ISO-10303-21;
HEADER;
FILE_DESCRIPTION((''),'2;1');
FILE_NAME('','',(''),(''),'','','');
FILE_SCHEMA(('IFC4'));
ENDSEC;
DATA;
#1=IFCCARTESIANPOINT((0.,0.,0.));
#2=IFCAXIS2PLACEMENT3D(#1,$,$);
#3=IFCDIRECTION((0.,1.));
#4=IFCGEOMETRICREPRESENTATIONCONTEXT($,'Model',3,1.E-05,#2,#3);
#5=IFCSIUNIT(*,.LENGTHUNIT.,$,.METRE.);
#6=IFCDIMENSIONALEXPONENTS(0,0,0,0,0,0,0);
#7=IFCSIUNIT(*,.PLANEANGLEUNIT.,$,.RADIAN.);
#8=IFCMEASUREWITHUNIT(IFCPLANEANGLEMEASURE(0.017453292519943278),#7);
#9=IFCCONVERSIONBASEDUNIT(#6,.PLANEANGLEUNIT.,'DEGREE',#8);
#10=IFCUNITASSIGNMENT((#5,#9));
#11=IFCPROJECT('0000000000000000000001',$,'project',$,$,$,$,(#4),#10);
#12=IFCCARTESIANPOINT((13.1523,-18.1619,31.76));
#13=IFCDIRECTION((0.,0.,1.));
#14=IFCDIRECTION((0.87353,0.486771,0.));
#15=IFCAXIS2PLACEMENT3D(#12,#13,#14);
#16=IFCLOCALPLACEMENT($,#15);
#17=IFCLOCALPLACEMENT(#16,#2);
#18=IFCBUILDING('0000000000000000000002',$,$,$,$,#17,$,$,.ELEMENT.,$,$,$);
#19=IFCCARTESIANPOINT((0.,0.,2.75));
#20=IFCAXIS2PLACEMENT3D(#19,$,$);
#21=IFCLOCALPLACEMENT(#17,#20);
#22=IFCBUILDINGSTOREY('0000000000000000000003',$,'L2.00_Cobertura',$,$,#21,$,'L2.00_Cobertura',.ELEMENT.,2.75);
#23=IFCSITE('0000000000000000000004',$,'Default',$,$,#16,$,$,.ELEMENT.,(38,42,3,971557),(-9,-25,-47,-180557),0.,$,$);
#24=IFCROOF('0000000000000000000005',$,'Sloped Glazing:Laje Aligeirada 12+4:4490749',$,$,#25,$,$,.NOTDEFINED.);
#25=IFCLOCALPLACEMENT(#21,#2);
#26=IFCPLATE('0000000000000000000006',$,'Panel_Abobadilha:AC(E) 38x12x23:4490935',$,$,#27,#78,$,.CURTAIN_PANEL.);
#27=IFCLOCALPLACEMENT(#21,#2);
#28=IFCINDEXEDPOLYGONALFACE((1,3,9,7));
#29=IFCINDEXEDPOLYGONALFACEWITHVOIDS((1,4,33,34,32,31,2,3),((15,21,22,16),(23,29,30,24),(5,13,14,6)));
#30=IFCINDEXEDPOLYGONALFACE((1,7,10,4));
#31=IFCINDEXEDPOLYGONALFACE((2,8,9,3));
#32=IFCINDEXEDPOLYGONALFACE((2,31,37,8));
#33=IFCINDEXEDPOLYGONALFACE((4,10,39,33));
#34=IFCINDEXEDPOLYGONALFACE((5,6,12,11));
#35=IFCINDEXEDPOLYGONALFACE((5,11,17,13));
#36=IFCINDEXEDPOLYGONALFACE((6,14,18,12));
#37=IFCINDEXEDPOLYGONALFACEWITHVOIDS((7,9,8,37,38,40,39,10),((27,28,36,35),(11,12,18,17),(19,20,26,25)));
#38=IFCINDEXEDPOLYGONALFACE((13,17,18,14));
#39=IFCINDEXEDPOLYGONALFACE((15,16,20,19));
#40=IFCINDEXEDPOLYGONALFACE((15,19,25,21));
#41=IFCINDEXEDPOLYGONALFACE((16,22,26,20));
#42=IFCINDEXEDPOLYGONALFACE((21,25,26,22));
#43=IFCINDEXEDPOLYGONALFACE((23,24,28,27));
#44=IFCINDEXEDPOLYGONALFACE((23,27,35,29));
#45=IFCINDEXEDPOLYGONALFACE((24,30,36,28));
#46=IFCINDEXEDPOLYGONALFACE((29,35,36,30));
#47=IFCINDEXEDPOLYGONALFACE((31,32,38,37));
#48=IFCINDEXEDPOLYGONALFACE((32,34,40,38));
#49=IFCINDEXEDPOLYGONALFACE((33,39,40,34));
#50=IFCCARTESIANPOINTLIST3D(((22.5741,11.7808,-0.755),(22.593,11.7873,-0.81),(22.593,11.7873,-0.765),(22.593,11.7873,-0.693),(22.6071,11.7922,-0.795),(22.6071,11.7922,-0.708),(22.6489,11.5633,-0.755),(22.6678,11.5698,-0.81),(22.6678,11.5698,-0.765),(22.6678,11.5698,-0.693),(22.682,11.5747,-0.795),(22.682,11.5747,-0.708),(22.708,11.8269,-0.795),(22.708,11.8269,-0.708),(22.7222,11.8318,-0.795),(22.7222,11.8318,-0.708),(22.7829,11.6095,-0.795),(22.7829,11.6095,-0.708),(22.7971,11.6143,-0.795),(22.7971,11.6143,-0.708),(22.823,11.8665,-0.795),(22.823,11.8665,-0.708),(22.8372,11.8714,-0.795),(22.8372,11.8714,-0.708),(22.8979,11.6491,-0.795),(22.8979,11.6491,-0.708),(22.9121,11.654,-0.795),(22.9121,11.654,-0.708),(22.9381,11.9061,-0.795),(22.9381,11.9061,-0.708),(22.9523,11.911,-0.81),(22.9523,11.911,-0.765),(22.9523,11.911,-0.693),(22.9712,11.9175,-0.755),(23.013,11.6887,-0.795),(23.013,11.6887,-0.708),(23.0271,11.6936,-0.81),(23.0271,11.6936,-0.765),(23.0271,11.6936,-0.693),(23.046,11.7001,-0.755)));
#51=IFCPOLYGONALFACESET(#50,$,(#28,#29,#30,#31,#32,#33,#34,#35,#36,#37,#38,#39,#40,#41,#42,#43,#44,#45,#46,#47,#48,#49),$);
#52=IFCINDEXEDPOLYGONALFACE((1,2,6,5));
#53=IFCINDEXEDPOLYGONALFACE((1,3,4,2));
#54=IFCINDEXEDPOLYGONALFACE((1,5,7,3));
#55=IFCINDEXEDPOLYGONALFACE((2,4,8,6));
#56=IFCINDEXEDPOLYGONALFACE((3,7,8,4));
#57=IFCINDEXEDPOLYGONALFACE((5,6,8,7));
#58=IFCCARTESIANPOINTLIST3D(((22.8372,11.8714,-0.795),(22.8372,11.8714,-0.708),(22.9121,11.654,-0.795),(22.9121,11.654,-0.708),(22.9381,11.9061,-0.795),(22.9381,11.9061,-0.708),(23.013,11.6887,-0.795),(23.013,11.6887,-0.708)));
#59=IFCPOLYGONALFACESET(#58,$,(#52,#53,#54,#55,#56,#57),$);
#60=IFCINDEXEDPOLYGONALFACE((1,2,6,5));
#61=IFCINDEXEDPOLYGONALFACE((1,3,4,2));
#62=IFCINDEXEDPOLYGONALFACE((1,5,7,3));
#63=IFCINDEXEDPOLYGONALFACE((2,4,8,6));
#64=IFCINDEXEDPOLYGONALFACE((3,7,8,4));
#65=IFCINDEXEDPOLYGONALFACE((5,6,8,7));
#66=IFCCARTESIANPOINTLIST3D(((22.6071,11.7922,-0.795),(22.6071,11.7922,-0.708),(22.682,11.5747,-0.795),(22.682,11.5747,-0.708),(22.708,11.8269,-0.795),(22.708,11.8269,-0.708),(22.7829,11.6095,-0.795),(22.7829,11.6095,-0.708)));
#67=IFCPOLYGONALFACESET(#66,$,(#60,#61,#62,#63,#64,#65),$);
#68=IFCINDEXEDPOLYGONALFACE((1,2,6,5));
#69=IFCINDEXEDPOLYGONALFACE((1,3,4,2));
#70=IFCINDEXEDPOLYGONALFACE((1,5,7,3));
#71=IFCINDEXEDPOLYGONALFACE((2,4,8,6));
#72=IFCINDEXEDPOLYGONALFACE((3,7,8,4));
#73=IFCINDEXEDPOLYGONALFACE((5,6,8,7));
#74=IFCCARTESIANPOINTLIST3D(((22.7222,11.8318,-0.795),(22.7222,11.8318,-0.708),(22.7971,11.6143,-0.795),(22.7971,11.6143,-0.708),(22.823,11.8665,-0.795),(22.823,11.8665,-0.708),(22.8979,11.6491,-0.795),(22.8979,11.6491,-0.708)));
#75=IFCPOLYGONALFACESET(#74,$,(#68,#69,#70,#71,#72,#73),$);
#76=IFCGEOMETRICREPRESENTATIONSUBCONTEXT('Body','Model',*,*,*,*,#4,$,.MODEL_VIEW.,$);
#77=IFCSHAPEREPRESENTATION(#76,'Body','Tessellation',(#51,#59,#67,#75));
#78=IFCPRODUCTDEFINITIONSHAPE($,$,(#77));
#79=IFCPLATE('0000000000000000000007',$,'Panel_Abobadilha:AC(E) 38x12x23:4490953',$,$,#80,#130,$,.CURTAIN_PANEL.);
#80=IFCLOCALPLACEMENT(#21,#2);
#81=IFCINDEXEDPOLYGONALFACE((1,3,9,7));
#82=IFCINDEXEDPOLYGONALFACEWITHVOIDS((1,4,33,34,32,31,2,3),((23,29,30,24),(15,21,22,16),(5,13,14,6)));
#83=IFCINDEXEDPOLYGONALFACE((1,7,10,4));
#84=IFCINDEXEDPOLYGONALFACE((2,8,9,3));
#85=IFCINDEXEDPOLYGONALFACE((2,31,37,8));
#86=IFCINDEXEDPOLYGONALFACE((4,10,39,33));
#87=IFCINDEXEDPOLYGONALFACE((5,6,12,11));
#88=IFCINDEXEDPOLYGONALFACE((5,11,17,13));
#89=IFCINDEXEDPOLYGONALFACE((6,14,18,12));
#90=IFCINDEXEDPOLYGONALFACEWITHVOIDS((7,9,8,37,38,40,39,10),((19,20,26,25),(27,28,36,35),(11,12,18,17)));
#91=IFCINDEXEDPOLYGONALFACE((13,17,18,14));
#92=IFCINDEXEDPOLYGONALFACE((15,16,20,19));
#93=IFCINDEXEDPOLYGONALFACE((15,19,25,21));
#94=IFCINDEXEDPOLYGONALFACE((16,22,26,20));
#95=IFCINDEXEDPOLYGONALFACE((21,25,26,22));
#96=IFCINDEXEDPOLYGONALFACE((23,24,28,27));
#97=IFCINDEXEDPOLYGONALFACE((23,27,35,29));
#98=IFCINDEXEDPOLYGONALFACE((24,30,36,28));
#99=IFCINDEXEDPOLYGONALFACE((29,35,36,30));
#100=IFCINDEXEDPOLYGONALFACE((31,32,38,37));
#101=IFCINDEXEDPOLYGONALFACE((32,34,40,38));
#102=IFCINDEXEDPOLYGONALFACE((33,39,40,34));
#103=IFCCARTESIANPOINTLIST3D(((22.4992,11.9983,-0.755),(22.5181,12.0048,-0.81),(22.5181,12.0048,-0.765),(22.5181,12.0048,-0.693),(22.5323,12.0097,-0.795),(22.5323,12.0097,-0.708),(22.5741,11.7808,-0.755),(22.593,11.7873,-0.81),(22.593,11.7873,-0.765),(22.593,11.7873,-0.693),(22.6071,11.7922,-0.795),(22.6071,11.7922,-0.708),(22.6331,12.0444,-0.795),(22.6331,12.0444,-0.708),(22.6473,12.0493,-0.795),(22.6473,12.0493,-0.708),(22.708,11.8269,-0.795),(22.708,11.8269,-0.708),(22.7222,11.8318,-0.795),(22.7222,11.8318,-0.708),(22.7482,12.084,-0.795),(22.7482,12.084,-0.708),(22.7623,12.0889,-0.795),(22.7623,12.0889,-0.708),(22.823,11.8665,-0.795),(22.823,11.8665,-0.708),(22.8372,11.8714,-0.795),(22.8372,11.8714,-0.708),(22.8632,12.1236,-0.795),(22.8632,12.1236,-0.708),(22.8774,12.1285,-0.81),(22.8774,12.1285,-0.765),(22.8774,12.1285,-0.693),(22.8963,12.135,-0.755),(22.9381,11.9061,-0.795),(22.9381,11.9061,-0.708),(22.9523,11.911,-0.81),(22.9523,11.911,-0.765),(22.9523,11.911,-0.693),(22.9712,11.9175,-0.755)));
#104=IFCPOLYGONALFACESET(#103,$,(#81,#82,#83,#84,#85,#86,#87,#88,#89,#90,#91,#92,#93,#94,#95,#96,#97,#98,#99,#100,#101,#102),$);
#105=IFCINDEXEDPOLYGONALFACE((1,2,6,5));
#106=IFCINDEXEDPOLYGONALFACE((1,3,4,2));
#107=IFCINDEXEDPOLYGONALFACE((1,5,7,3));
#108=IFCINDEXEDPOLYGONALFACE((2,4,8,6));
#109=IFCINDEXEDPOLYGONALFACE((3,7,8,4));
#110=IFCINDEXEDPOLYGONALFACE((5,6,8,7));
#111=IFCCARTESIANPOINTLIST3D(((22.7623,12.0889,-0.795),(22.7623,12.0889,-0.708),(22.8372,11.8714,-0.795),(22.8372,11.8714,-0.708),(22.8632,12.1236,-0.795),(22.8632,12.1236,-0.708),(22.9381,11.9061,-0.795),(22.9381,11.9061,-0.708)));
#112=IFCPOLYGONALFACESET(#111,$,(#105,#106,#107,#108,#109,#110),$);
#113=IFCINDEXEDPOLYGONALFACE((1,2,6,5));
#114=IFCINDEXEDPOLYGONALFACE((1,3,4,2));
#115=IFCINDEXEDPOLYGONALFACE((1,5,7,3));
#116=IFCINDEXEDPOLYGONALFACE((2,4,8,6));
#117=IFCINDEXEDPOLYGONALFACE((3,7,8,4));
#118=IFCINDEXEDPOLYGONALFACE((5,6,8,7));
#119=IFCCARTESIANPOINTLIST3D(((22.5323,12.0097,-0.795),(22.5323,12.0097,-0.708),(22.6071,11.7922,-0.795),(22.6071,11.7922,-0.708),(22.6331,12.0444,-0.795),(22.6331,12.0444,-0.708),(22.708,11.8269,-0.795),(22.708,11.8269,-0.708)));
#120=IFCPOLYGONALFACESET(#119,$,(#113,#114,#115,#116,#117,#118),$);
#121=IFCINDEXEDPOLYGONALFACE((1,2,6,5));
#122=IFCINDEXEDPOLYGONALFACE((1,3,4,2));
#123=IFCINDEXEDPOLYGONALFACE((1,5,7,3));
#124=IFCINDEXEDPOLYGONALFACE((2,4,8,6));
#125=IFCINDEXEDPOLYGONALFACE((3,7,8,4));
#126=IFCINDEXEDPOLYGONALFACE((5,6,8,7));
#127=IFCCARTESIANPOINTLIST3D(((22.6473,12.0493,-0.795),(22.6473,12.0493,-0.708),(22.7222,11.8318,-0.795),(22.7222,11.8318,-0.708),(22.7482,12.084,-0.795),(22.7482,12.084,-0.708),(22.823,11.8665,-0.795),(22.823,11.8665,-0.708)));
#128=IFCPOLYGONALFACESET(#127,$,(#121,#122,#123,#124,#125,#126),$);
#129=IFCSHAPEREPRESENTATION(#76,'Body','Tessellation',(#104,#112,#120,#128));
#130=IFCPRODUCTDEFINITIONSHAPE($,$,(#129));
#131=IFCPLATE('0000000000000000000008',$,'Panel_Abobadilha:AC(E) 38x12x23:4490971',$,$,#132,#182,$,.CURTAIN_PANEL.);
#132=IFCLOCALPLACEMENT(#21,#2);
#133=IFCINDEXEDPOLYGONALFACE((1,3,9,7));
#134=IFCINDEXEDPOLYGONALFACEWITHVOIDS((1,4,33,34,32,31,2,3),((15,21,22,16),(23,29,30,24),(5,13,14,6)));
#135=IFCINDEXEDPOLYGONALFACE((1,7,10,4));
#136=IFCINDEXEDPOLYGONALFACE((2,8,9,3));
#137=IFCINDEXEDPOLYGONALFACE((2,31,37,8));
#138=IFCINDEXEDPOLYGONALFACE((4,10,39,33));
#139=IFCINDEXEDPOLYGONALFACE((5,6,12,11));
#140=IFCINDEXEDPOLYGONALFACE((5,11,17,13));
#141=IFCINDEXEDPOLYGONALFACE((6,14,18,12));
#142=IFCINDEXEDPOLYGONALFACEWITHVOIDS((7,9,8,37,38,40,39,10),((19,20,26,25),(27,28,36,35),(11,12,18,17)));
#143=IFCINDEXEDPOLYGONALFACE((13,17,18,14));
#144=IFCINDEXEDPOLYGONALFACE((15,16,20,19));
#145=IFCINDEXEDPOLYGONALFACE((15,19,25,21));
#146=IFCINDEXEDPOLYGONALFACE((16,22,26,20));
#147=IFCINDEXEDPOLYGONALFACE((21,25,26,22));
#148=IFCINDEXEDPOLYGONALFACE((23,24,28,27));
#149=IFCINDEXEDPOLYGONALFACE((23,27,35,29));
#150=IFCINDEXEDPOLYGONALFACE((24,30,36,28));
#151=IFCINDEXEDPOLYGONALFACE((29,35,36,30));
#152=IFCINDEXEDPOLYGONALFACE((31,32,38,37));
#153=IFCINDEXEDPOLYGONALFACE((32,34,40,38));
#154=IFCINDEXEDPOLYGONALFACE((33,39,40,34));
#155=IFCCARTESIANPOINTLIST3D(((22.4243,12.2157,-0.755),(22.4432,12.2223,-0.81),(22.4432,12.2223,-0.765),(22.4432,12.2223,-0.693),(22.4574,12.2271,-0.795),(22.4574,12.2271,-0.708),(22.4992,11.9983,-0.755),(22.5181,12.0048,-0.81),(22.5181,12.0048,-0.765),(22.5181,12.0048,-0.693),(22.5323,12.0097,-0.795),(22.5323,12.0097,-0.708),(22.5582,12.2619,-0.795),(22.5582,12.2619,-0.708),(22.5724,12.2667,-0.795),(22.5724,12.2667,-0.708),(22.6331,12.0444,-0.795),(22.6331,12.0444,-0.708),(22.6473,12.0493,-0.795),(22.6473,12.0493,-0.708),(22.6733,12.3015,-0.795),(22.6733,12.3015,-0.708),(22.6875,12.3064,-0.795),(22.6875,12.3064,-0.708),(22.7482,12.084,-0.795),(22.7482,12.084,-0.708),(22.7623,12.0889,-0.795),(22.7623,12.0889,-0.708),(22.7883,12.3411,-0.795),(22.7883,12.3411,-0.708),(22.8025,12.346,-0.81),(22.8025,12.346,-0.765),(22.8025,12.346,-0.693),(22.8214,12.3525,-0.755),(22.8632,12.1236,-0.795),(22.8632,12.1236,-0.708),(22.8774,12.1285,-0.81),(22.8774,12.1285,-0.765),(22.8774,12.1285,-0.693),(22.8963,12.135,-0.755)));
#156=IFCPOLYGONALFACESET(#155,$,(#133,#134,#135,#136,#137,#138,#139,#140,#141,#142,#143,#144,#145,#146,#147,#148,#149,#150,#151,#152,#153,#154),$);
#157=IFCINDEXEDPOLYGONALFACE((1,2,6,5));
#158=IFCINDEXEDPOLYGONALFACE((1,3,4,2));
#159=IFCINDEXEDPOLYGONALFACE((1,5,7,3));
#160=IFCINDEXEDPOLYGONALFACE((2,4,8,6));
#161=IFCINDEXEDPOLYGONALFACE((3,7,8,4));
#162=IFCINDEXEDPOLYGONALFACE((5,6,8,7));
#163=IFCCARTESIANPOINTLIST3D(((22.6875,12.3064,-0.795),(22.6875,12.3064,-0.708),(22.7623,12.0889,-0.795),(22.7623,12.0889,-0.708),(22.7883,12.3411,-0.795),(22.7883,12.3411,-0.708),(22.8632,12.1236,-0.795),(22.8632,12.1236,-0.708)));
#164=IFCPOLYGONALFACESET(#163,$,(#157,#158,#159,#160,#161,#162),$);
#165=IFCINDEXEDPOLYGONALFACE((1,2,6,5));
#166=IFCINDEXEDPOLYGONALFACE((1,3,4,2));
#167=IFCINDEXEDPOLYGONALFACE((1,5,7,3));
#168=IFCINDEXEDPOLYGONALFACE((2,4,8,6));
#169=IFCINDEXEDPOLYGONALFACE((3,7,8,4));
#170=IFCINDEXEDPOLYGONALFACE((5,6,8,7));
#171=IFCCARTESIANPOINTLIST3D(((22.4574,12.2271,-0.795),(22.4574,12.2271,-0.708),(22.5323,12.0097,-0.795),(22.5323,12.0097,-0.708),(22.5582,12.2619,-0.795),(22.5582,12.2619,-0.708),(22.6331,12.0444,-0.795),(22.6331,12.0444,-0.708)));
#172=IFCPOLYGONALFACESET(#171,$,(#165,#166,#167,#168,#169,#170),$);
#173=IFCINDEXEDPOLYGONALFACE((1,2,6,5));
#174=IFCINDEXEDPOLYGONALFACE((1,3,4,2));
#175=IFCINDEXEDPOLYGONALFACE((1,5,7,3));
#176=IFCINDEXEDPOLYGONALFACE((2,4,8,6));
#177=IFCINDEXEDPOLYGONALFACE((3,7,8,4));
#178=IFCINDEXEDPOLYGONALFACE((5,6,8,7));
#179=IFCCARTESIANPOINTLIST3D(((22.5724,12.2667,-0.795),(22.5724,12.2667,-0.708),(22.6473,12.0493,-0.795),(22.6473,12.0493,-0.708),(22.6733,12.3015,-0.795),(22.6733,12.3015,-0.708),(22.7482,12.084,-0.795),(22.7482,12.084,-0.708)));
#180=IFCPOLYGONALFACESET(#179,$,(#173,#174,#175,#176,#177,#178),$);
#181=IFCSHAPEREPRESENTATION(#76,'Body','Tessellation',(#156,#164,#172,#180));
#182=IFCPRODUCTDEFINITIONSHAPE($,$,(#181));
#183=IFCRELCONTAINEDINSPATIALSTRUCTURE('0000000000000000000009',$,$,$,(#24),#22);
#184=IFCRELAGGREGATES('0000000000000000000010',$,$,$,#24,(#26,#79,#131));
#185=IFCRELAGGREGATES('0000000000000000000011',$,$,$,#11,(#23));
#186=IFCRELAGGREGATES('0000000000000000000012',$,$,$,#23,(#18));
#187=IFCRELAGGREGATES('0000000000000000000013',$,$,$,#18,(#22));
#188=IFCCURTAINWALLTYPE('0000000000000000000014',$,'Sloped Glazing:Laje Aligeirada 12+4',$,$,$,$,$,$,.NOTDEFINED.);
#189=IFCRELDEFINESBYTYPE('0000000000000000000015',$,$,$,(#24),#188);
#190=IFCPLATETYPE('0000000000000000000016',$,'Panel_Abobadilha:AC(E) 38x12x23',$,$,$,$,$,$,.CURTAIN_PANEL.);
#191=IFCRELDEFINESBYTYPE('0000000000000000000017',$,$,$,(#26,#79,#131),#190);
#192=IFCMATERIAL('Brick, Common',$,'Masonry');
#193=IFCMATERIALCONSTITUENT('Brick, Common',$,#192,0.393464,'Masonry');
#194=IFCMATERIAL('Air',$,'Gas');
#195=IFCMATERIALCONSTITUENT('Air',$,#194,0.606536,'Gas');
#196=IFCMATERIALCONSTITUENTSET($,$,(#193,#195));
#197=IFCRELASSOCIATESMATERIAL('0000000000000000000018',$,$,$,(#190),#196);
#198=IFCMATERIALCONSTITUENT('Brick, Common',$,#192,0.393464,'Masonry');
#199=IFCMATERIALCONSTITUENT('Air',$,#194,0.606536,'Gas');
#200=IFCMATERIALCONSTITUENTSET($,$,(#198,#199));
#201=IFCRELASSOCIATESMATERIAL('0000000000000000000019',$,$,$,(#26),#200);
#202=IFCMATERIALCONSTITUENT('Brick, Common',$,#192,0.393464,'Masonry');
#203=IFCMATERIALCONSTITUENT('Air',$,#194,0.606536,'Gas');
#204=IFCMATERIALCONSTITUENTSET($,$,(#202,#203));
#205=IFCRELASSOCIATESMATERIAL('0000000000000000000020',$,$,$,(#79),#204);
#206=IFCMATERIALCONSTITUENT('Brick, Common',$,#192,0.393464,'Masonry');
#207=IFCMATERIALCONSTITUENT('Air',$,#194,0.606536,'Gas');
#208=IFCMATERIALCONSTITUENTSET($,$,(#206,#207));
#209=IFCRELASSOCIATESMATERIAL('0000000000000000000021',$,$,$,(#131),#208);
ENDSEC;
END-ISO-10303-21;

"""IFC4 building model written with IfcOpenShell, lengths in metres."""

from ifc_helpers import new_model, entity, si_unit, converted_unit, direction, frame, origin, place, context, subcontext, project, spatial, indexed_curve, outline, extrude, source, transform, mapped, material, constituent, constituent_set, type_object, type_shapes, element, aggregate, save


model = new_model("IFC4")

# Units and contexts
model_context = context("Model", 3, precision=1e-05, world=origin(), true_north=direction((0.0, 1.0)))
body_context = subcontext(model_context, "Body", "Model", "MODEL_VIEW")
ifc_project = project(units=[si_unit("LENGTHUNIT", "METRE"), converted_unit("PLANEANGLEUNIT", "DEGREE", entity("IfcPlaneAngleMeasure", 0.017453292519943278), si_unit("PLANEANGLEUNIT", "RADIAN"), dimensions=[0, 0, 0, 0, 0, 0, 0])], contexts=[model_context])

# Site, building, storey
site_placement = place(None, frame((13.1523, -18.1619, 31.76), z_axis=(0.0, 0.0, 1.0), x_axis=(0.87353, 0.486771, 0.0)))
site = spatial("IfcSite", under=ifc_project, at=site_placement, Name="Default", CompositionType="ELEMENT", RefLatitude=(38, 42, 3, 971557), RefLongitude=(-9, -25, -47, -180557), RefElevation=0.0)
building_placement = place(site_placement, origin())
building = spatial("IfcBuilding", under=site, at=building_placement, CompositionType="ELEMENT")
storey_placement = place(building_placement, frame((0.0, 0.0, 2.75)))
storey = spatial("IfcBuildingStorey", under=building, at=storey_placement, Name="L2.00_Cobertura", LongName="L2.00_Cobertura", CompositionType="ELEMENT", Elevation=2.75)

# Roof, plates
curtain_wall_type = type_object("IfcCurtainWallType", Name="Sloped Glazing:Laje Aligeirada 12+4", PredefinedType="NOTDEFINED")
roof_placement = place(storey_placement, frame((0.0, 0.0, -2.75)))
roof = element("IfcRoof", 1, at=roof_placement, inside=storey, type_object=curtain_wall_type, Name="Sloped Glazing:Laje Aligeirada 12+4:4490749", PredefinedType="NOTDEFINED")
ifc_material_1 = material(Name="Brick, Common", Category="Masonry")
ifc_constituent_1 = constituent(ifc_material_1, Name="Brick, Common", Category="Masonry", fraction=0.393464)
ifc_material_2 = material(Name="Air", Category="Gas")
ifc_constituent_2 = constituent(ifc_material_2, Name="Air", Category="Gas", fraction=0.606536)
ifc_constituent_set_1 = constituent_set(constituents=[ifc_constituent_1, ifc_constituent_2])
ifc_constituent_3 = constituent(ifc_material_1, Name="Brick, Common", Category="Masonry", fraction=0.393464)
ifc_constituent_4 = constituent(ifc_material_2, Name="Air", Category="Gas", fraction=0.606536)
ifc_constituent_set_2 = constituent_set(constituents=[ifc_constituent_3, ifc_constituent_4])
plate_type = type_object("IfcPlateType", Name="Panel_Abobadilha:AC(E) 38x12x23", PredefinedType="CURTAIN_PANEL", material=ifc_constituent_set_2)
shared_shape_1 = source(origin(), body_context, "Body", "SweptSolid", [
    extrude(outline(indexed_curve([(-0.19, -0.0543), (0.19, -0.0543), (0.19, -0.0093), (0.21, 0.0007), (0.19, 0.0628), (-0.19, 0.0628), (-0.21, 0.0007), (-0.19, -0.0093), (-0.19, -0.0543)], self_intersect=False), holes=[indexed_curve([(-0.0683, 0.0477), (-0.0683, -0.0393), (-0.175, -0.0393), (-0.175, 0.0477), (-0.0683, 0.0477)], self_intersect=False), indexed_curve([(0.0533, 0.0477), (0.0533, -0.0393), (-0.0533, -0.0393), (-0.0533, 0.0477), (0.0533, 0.0477)], self_intersect=False), indexed_curve([(0.175, 0.0477), (0.175, -0.0393), (0.0683, -0.0393), (0.0683, 0.0477), (0.175, 0.0477)], self_intersect=False)]), frame((0.0, 0.0543, 0.0)), (0.0, 0.0, 1.0), 0.23),
    extrude(outline(indexed_curve([(-0.0533, -0.0435), (0.0533, -0.0435), (0.0533, 0.0435), (-0.0533, 0.0435), (-0.0533, -0.0435)], self_intersect=False)), frame((0.1217, 0.0585, 0.0), z_axis=(0.0, 0.0, 1.0), x_axis=(-1.0, 0.0, 0.0)), (0.0, 0.0, 1.0), 0.23),
    extrude(outline(indexed_curve([(-0.0533, -0.0435), (0.0533, -0.0435), (0.0533, 0.0435), (-0.0533, 0.0435), (-0.0533, -0.0435)], self_intersect=False)), frame((-0.1217, 0.0585, 0.0), z_axis=(0.0, 0.0, 1.0), x_axis=(-1.0, 0.0, 0.0)), (0.0, 0.0, 1.0), 0.23),
    extrude(outline(indexed_curve([(-0.0533, -0.0435), (0.0533, -0.0435), (0.0533, 0.0435), (-0.0533, 0.0435), (-0.0533, -0.0435)], self_intersect=False)), frame((0.0, 0.0585, 0.0), z_axis=(0.0, 0.0, 1.0), x_axis=(-1.0, 0.0, 0.0)), (0.0, 0.0, 1.0), 0.23),
])
type_shapes(plate_type, [shared_shape_1])
plate_1_placement = place(roof_placement, frame((22.7726, 11.8492, 1.94), z_axis=(0.325568, -0.945519, 0.0), x_axis=(0.945519, 0.325568, 0.0)))
plate_1 = element("IfcPlate", 2, at=plate_1_placement, type_object=plate_type, material=ifc_constituent_set_1, Name="Panel_Abobadilha:AC(E) 38x12x23:4490935", PredefinedType="CURTAIN_PANEL", context=body_context, shape_type="MappedRepresentation", body=[
    mapped(shared_shape_1, transform((0.0, 0.0, 0.0), scale=1.0)),
])
ifc_constituent_5 = constituent(ifc_material_1, Name="Brick, Common", Category="Masonry", fraction=0.393464)
ifc_constituent_6 = constituent(ifc_material_2, Name="Air", Category="Gas", fraction=0.606536)
ifc_constituent_set_3 = constituent_set(constituents=[ifc_constituent_5, ifc_constituent_6])
plate_2_placement = place(roof_placement, frame((22.6977, 12.0666, 1.94), z_axis=(0.325568, -0.945519, 0.0), x_axis=(0.945519, 0.325568, 0.0)))
plate_2 = element("IfcPlate", 3, at=plate_2_placement, type_object=plate_type, material=ifc_constituent_set_3, Name="Panel_Abobadilha:AC(E) 38x12x23:4490953", PredefinedType="CURTAIN_PANEL", context=body_context, shape_type="MappedRepresentation", body=[
    mapped(shared_shape_1, transform((0.0, 0.0, 0.0), scale=1.0)),
])
ifc_constituent_7 = constituent(ifc_material_1, Name="Brick, Common", Category="Masonry", fraction=0.393464)
ifc_constituent_8 = constituent(ifc_material_2, Name="Air", Category="Gas", fraction=0.606536)
ifc_constituent_set_4 = constituent_set(constituents=[ifc_constituent_7, ifc_constituent_8])
plate_3_placement = place(roof_placement, frame((22.6228, 12.2841, 1.94), z_axis=(0.325568, -0.945519, 0.0), x_axis=(0.945519, 0.325568, 0.0)))
plate_3 = element("IfcPlate", 4, at=plate_3_placement, type_object=plate_type, material=ifc_constituent_set_4, Name="Panel_Abobadilha:AC(E) 38x12x23:4490971", PredefinedType="CURTAIN_PANEL", context=body_context, shape_type="MappedRepresentation", body=[
    mapped(shared_shape_1, transform((0.0, 0.0, 0.0), scale=1.0)),
])
aggregate(roof, [plate_1, plate_2, plate_3])

save(model, "model.ifc")
